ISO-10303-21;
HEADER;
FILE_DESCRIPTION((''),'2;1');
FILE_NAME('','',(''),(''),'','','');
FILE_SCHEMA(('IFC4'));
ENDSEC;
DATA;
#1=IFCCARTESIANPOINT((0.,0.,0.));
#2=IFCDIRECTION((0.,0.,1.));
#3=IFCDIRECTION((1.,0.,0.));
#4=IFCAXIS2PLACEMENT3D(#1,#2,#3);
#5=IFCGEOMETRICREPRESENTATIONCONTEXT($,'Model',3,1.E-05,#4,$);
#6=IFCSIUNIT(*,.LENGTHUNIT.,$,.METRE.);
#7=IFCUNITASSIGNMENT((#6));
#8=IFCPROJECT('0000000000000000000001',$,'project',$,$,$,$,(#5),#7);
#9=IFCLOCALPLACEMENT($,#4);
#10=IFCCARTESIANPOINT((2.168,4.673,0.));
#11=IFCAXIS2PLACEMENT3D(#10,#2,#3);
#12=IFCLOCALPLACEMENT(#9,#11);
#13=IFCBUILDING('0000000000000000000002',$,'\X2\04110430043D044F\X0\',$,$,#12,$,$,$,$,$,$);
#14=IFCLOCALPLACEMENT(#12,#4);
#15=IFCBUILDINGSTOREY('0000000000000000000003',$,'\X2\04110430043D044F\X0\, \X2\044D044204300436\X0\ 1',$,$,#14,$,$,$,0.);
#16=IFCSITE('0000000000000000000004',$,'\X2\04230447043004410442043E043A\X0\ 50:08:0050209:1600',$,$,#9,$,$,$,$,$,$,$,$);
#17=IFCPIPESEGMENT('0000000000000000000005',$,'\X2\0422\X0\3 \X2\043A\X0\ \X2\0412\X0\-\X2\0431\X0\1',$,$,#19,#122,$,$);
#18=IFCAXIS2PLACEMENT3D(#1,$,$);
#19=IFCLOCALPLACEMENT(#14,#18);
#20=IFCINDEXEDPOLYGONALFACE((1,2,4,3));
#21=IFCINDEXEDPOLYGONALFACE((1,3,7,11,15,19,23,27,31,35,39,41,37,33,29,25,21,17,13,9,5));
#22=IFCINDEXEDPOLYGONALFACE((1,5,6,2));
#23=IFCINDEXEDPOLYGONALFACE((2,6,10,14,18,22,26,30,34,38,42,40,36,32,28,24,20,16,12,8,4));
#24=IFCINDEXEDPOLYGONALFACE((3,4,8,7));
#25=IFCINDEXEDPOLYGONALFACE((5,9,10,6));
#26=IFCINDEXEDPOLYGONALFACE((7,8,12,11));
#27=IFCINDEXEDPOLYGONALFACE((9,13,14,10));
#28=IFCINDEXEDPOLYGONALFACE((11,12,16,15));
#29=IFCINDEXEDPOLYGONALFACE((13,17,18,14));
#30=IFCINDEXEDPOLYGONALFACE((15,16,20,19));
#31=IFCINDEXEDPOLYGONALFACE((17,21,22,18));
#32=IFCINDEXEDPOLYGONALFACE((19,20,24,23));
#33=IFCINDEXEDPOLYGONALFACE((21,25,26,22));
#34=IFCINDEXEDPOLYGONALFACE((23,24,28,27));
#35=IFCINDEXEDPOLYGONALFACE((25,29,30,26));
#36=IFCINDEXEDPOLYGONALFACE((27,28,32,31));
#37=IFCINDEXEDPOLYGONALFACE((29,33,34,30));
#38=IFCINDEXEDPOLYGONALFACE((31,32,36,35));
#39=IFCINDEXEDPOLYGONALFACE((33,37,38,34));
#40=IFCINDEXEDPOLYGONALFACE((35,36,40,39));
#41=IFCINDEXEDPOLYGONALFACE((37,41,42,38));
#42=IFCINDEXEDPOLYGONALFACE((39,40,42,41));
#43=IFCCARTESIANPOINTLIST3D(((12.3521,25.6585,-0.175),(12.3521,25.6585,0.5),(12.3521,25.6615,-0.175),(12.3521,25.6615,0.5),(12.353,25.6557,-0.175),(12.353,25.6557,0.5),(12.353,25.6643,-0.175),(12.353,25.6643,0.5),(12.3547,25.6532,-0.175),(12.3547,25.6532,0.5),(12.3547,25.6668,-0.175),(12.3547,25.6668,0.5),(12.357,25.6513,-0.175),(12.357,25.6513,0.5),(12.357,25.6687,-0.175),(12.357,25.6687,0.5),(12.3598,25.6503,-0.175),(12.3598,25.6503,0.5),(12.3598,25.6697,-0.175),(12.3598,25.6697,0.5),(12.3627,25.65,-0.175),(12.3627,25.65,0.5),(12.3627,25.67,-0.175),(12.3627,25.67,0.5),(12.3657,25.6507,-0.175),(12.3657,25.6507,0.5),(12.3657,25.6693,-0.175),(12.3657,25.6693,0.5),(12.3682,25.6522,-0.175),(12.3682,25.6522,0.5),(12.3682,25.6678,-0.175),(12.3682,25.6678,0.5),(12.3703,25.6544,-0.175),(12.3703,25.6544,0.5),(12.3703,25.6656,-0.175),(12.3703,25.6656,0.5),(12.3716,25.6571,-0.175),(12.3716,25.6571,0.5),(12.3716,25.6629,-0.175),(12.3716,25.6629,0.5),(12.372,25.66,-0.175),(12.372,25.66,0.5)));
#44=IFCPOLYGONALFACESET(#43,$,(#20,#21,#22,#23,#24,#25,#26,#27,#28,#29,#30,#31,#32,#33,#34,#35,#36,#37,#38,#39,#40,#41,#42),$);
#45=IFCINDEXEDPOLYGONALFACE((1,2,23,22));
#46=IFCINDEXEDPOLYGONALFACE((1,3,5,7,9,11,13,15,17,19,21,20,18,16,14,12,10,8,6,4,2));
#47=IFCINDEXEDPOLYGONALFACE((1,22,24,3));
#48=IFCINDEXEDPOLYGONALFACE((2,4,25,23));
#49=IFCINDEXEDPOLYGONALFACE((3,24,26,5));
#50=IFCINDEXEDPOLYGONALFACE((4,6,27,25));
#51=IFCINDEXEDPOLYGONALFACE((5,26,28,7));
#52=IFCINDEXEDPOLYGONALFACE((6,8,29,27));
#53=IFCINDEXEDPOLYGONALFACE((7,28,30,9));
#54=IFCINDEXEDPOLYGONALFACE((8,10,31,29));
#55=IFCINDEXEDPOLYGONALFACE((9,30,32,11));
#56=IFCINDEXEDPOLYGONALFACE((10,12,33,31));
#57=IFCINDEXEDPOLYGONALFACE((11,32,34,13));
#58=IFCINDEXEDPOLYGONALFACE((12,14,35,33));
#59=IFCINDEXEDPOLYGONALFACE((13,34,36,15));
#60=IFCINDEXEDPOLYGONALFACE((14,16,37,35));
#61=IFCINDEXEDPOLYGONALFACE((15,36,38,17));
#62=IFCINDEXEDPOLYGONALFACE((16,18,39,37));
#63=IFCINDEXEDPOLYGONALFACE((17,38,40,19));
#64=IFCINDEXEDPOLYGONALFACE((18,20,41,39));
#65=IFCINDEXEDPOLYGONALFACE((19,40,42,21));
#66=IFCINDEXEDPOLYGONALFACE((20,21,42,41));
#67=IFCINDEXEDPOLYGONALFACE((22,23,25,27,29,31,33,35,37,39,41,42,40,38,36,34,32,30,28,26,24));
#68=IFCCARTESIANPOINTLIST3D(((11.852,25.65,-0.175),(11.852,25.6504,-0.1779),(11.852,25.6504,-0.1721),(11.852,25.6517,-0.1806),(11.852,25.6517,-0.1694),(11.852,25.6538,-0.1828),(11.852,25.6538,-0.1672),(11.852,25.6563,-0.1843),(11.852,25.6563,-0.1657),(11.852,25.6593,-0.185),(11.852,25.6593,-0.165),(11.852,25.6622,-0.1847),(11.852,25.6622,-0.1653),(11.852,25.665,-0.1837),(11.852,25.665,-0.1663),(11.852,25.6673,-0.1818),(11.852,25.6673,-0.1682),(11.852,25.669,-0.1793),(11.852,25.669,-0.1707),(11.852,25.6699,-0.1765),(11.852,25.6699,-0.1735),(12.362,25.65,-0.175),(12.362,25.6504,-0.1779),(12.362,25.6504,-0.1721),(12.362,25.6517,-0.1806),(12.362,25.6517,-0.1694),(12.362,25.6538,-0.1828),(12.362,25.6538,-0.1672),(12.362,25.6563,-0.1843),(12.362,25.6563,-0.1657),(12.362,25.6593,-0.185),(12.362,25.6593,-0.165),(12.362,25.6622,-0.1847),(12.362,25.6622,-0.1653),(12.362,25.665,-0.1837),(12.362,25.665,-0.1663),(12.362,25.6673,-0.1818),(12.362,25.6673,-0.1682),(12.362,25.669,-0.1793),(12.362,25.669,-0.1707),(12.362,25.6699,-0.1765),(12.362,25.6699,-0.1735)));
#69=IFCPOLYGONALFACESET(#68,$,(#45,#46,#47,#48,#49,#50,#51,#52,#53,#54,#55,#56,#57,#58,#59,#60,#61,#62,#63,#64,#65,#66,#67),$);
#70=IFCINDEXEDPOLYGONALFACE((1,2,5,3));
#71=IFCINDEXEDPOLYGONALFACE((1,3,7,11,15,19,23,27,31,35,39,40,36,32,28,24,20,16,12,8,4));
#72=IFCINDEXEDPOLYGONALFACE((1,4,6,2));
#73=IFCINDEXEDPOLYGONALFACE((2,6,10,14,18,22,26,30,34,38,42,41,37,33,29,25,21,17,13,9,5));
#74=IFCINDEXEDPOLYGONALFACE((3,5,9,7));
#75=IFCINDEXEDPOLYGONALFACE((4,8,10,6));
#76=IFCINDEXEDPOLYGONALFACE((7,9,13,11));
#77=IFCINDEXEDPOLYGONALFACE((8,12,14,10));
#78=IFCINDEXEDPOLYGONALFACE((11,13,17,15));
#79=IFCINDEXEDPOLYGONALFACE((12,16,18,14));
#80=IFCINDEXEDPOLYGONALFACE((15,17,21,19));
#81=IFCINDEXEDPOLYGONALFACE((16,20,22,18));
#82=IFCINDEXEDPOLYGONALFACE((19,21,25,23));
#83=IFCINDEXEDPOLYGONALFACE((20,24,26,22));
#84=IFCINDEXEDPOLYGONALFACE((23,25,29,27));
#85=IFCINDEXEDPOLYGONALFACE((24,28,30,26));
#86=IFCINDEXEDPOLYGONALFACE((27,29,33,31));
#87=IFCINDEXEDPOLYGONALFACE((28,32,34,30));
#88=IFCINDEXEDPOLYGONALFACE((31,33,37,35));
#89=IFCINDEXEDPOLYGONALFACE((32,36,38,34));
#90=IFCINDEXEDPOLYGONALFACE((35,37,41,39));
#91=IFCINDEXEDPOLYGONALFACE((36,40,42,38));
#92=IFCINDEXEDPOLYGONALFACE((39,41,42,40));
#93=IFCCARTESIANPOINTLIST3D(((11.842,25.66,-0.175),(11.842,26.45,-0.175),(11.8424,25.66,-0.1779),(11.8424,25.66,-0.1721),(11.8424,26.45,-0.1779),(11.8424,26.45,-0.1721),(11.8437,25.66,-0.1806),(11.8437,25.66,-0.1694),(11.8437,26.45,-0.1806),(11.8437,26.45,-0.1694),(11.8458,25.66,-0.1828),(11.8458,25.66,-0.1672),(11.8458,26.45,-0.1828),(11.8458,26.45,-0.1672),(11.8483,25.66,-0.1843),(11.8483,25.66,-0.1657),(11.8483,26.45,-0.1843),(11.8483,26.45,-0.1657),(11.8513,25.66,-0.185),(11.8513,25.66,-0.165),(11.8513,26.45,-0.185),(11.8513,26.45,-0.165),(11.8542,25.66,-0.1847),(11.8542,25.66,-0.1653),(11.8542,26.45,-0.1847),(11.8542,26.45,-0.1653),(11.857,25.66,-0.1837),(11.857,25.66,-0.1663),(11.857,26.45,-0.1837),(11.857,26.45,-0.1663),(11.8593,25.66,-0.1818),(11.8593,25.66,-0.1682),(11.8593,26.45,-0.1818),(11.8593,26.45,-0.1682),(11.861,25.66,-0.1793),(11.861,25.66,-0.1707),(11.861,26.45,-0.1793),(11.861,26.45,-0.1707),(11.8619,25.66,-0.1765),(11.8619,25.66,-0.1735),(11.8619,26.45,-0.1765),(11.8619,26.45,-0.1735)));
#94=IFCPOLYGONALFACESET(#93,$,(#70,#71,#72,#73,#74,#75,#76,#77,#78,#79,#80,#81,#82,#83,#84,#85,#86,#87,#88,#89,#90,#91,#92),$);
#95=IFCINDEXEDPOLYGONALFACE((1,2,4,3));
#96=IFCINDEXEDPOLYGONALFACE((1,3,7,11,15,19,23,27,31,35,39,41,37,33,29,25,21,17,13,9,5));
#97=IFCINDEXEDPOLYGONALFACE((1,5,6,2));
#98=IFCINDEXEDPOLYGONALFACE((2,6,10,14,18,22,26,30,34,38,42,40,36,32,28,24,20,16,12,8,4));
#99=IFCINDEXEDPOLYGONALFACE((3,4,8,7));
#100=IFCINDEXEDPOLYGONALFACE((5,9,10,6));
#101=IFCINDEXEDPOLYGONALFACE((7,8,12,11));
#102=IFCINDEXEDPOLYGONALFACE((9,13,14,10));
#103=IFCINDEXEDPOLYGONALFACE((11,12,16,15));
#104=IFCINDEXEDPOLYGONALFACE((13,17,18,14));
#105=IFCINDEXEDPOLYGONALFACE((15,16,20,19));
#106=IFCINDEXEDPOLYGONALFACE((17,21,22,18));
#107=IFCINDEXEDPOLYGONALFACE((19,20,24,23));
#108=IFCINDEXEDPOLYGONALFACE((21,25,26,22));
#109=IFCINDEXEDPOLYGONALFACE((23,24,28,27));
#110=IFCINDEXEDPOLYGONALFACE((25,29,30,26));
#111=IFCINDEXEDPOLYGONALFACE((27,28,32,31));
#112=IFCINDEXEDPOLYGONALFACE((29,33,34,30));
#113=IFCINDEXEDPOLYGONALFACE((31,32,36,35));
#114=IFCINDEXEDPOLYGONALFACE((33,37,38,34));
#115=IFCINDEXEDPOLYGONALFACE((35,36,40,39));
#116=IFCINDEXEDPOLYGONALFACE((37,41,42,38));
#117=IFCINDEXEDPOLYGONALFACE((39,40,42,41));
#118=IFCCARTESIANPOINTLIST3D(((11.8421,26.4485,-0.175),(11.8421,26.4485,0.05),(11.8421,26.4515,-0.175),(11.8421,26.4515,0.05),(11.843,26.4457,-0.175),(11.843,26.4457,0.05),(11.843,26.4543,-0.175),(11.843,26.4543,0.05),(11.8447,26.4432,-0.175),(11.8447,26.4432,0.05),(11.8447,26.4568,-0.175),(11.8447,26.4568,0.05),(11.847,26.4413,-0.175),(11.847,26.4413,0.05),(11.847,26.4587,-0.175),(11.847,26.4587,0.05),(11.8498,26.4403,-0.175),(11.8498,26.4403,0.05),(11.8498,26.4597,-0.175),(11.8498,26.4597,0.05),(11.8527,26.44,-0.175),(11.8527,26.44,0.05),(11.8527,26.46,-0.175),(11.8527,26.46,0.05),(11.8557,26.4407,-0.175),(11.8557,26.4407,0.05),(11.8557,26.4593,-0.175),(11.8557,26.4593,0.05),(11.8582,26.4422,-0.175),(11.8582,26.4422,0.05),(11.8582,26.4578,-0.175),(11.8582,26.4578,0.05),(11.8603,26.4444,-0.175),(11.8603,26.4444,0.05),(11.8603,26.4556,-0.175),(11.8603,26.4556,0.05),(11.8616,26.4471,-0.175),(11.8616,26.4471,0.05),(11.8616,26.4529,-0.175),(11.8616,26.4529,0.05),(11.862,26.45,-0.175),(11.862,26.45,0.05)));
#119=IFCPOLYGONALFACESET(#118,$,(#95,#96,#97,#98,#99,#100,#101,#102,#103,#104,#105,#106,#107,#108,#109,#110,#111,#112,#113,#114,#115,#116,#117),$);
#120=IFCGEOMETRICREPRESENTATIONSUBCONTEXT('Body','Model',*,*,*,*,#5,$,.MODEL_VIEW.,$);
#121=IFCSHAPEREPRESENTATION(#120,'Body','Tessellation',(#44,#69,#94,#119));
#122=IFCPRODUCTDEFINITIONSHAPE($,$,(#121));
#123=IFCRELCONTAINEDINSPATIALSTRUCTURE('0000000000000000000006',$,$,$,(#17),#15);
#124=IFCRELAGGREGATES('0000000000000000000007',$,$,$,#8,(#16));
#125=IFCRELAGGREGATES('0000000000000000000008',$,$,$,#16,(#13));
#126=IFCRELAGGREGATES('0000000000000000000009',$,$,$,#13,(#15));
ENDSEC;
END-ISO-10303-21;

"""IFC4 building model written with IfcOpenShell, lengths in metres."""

from ifc_helpers import new_model, si_unit, frame, origin_with_axes, origin_2d, place, context, subcontext, project, spatial, circle, extrude, element, save


model = new_model("IFC4")

# Units and contexts
model_context = context("Model", 3, precision=1e-05, world=origin_with_axes())
body_context = subcontext(model_context, "Body", "Model", "MODEL_VIEW")
ifc_project = project(units=[si_unit("LENGTHUNIT", "METRE")], contexts=[model_context])

# Site, building, storey
site_placement = place(None, origin_with_axes())
site = spatial("IfcSite", under=ifc_project, at=site_placement, Name="Участок 50:08:0050209:1600")
building_placement = place(site_placement, frame((2.168, 4.673, 0.0), z_axis=(0.0, 0.0, 1.0), x_axis=(1.0, 0.0, 0.0)))
building = spatial("IfcBuilding", under=site, at=building_placement, Name="Баня")
storey_placement = place(building_placement, origin_with_axes())
storey = spatial("IfcBuildingStorey", under=building, at=storey_placement, Name="Баня, этаж 1", Elevation=0.0)

# Pipe segment
pipe_segment_1_placement = place(storey_placement, origin_with_axes())
element("IfcPipeSegment", 1, at=pipe_segment_1_placement, inside=storey, Name="Т3 к В-б1", context=body_context, shape_type="SweptSolid", body=[
    extrude(circle(Radius=0.01, at=origin_2d()), frame((12.362, 25.66, 0.5), z_axis=(0.0, 0.0, -1.0), x_axis=(1.0, 0.0, 0.0)), (0.0, 0.0, 1.0), 0.675),
    extrude(circle(Radius=0.01, at=origin_2d()), frame((12.362, 25.66, -0.175), z_axis=(-1.0, 0.0, 0.0), x_axis=(0.0, -1.0, 0.0)), (0.0, 0.0, 1.0), 0.51),
    extrude(circle(Radius=0.01, at=origin_2d()), frame((11.852, 25.66, -0.175), z_axis=(0.0, 1.0, 0.0), x_axis=(-1.0, 0.0, 0.0)), (0.0, 0.0, 1.0), 0.79),
    extrude(circle(Radius=0.01, at=origin_2d()), frame((11.852, 26.45, -0.175), z_axis=(0.0, 0.0, 1.0), x_axis=(1.0, 0.0, 0.0)), (0.0, 0.0, 1.0), 0.225),
])

save(model, "model.ifc")
